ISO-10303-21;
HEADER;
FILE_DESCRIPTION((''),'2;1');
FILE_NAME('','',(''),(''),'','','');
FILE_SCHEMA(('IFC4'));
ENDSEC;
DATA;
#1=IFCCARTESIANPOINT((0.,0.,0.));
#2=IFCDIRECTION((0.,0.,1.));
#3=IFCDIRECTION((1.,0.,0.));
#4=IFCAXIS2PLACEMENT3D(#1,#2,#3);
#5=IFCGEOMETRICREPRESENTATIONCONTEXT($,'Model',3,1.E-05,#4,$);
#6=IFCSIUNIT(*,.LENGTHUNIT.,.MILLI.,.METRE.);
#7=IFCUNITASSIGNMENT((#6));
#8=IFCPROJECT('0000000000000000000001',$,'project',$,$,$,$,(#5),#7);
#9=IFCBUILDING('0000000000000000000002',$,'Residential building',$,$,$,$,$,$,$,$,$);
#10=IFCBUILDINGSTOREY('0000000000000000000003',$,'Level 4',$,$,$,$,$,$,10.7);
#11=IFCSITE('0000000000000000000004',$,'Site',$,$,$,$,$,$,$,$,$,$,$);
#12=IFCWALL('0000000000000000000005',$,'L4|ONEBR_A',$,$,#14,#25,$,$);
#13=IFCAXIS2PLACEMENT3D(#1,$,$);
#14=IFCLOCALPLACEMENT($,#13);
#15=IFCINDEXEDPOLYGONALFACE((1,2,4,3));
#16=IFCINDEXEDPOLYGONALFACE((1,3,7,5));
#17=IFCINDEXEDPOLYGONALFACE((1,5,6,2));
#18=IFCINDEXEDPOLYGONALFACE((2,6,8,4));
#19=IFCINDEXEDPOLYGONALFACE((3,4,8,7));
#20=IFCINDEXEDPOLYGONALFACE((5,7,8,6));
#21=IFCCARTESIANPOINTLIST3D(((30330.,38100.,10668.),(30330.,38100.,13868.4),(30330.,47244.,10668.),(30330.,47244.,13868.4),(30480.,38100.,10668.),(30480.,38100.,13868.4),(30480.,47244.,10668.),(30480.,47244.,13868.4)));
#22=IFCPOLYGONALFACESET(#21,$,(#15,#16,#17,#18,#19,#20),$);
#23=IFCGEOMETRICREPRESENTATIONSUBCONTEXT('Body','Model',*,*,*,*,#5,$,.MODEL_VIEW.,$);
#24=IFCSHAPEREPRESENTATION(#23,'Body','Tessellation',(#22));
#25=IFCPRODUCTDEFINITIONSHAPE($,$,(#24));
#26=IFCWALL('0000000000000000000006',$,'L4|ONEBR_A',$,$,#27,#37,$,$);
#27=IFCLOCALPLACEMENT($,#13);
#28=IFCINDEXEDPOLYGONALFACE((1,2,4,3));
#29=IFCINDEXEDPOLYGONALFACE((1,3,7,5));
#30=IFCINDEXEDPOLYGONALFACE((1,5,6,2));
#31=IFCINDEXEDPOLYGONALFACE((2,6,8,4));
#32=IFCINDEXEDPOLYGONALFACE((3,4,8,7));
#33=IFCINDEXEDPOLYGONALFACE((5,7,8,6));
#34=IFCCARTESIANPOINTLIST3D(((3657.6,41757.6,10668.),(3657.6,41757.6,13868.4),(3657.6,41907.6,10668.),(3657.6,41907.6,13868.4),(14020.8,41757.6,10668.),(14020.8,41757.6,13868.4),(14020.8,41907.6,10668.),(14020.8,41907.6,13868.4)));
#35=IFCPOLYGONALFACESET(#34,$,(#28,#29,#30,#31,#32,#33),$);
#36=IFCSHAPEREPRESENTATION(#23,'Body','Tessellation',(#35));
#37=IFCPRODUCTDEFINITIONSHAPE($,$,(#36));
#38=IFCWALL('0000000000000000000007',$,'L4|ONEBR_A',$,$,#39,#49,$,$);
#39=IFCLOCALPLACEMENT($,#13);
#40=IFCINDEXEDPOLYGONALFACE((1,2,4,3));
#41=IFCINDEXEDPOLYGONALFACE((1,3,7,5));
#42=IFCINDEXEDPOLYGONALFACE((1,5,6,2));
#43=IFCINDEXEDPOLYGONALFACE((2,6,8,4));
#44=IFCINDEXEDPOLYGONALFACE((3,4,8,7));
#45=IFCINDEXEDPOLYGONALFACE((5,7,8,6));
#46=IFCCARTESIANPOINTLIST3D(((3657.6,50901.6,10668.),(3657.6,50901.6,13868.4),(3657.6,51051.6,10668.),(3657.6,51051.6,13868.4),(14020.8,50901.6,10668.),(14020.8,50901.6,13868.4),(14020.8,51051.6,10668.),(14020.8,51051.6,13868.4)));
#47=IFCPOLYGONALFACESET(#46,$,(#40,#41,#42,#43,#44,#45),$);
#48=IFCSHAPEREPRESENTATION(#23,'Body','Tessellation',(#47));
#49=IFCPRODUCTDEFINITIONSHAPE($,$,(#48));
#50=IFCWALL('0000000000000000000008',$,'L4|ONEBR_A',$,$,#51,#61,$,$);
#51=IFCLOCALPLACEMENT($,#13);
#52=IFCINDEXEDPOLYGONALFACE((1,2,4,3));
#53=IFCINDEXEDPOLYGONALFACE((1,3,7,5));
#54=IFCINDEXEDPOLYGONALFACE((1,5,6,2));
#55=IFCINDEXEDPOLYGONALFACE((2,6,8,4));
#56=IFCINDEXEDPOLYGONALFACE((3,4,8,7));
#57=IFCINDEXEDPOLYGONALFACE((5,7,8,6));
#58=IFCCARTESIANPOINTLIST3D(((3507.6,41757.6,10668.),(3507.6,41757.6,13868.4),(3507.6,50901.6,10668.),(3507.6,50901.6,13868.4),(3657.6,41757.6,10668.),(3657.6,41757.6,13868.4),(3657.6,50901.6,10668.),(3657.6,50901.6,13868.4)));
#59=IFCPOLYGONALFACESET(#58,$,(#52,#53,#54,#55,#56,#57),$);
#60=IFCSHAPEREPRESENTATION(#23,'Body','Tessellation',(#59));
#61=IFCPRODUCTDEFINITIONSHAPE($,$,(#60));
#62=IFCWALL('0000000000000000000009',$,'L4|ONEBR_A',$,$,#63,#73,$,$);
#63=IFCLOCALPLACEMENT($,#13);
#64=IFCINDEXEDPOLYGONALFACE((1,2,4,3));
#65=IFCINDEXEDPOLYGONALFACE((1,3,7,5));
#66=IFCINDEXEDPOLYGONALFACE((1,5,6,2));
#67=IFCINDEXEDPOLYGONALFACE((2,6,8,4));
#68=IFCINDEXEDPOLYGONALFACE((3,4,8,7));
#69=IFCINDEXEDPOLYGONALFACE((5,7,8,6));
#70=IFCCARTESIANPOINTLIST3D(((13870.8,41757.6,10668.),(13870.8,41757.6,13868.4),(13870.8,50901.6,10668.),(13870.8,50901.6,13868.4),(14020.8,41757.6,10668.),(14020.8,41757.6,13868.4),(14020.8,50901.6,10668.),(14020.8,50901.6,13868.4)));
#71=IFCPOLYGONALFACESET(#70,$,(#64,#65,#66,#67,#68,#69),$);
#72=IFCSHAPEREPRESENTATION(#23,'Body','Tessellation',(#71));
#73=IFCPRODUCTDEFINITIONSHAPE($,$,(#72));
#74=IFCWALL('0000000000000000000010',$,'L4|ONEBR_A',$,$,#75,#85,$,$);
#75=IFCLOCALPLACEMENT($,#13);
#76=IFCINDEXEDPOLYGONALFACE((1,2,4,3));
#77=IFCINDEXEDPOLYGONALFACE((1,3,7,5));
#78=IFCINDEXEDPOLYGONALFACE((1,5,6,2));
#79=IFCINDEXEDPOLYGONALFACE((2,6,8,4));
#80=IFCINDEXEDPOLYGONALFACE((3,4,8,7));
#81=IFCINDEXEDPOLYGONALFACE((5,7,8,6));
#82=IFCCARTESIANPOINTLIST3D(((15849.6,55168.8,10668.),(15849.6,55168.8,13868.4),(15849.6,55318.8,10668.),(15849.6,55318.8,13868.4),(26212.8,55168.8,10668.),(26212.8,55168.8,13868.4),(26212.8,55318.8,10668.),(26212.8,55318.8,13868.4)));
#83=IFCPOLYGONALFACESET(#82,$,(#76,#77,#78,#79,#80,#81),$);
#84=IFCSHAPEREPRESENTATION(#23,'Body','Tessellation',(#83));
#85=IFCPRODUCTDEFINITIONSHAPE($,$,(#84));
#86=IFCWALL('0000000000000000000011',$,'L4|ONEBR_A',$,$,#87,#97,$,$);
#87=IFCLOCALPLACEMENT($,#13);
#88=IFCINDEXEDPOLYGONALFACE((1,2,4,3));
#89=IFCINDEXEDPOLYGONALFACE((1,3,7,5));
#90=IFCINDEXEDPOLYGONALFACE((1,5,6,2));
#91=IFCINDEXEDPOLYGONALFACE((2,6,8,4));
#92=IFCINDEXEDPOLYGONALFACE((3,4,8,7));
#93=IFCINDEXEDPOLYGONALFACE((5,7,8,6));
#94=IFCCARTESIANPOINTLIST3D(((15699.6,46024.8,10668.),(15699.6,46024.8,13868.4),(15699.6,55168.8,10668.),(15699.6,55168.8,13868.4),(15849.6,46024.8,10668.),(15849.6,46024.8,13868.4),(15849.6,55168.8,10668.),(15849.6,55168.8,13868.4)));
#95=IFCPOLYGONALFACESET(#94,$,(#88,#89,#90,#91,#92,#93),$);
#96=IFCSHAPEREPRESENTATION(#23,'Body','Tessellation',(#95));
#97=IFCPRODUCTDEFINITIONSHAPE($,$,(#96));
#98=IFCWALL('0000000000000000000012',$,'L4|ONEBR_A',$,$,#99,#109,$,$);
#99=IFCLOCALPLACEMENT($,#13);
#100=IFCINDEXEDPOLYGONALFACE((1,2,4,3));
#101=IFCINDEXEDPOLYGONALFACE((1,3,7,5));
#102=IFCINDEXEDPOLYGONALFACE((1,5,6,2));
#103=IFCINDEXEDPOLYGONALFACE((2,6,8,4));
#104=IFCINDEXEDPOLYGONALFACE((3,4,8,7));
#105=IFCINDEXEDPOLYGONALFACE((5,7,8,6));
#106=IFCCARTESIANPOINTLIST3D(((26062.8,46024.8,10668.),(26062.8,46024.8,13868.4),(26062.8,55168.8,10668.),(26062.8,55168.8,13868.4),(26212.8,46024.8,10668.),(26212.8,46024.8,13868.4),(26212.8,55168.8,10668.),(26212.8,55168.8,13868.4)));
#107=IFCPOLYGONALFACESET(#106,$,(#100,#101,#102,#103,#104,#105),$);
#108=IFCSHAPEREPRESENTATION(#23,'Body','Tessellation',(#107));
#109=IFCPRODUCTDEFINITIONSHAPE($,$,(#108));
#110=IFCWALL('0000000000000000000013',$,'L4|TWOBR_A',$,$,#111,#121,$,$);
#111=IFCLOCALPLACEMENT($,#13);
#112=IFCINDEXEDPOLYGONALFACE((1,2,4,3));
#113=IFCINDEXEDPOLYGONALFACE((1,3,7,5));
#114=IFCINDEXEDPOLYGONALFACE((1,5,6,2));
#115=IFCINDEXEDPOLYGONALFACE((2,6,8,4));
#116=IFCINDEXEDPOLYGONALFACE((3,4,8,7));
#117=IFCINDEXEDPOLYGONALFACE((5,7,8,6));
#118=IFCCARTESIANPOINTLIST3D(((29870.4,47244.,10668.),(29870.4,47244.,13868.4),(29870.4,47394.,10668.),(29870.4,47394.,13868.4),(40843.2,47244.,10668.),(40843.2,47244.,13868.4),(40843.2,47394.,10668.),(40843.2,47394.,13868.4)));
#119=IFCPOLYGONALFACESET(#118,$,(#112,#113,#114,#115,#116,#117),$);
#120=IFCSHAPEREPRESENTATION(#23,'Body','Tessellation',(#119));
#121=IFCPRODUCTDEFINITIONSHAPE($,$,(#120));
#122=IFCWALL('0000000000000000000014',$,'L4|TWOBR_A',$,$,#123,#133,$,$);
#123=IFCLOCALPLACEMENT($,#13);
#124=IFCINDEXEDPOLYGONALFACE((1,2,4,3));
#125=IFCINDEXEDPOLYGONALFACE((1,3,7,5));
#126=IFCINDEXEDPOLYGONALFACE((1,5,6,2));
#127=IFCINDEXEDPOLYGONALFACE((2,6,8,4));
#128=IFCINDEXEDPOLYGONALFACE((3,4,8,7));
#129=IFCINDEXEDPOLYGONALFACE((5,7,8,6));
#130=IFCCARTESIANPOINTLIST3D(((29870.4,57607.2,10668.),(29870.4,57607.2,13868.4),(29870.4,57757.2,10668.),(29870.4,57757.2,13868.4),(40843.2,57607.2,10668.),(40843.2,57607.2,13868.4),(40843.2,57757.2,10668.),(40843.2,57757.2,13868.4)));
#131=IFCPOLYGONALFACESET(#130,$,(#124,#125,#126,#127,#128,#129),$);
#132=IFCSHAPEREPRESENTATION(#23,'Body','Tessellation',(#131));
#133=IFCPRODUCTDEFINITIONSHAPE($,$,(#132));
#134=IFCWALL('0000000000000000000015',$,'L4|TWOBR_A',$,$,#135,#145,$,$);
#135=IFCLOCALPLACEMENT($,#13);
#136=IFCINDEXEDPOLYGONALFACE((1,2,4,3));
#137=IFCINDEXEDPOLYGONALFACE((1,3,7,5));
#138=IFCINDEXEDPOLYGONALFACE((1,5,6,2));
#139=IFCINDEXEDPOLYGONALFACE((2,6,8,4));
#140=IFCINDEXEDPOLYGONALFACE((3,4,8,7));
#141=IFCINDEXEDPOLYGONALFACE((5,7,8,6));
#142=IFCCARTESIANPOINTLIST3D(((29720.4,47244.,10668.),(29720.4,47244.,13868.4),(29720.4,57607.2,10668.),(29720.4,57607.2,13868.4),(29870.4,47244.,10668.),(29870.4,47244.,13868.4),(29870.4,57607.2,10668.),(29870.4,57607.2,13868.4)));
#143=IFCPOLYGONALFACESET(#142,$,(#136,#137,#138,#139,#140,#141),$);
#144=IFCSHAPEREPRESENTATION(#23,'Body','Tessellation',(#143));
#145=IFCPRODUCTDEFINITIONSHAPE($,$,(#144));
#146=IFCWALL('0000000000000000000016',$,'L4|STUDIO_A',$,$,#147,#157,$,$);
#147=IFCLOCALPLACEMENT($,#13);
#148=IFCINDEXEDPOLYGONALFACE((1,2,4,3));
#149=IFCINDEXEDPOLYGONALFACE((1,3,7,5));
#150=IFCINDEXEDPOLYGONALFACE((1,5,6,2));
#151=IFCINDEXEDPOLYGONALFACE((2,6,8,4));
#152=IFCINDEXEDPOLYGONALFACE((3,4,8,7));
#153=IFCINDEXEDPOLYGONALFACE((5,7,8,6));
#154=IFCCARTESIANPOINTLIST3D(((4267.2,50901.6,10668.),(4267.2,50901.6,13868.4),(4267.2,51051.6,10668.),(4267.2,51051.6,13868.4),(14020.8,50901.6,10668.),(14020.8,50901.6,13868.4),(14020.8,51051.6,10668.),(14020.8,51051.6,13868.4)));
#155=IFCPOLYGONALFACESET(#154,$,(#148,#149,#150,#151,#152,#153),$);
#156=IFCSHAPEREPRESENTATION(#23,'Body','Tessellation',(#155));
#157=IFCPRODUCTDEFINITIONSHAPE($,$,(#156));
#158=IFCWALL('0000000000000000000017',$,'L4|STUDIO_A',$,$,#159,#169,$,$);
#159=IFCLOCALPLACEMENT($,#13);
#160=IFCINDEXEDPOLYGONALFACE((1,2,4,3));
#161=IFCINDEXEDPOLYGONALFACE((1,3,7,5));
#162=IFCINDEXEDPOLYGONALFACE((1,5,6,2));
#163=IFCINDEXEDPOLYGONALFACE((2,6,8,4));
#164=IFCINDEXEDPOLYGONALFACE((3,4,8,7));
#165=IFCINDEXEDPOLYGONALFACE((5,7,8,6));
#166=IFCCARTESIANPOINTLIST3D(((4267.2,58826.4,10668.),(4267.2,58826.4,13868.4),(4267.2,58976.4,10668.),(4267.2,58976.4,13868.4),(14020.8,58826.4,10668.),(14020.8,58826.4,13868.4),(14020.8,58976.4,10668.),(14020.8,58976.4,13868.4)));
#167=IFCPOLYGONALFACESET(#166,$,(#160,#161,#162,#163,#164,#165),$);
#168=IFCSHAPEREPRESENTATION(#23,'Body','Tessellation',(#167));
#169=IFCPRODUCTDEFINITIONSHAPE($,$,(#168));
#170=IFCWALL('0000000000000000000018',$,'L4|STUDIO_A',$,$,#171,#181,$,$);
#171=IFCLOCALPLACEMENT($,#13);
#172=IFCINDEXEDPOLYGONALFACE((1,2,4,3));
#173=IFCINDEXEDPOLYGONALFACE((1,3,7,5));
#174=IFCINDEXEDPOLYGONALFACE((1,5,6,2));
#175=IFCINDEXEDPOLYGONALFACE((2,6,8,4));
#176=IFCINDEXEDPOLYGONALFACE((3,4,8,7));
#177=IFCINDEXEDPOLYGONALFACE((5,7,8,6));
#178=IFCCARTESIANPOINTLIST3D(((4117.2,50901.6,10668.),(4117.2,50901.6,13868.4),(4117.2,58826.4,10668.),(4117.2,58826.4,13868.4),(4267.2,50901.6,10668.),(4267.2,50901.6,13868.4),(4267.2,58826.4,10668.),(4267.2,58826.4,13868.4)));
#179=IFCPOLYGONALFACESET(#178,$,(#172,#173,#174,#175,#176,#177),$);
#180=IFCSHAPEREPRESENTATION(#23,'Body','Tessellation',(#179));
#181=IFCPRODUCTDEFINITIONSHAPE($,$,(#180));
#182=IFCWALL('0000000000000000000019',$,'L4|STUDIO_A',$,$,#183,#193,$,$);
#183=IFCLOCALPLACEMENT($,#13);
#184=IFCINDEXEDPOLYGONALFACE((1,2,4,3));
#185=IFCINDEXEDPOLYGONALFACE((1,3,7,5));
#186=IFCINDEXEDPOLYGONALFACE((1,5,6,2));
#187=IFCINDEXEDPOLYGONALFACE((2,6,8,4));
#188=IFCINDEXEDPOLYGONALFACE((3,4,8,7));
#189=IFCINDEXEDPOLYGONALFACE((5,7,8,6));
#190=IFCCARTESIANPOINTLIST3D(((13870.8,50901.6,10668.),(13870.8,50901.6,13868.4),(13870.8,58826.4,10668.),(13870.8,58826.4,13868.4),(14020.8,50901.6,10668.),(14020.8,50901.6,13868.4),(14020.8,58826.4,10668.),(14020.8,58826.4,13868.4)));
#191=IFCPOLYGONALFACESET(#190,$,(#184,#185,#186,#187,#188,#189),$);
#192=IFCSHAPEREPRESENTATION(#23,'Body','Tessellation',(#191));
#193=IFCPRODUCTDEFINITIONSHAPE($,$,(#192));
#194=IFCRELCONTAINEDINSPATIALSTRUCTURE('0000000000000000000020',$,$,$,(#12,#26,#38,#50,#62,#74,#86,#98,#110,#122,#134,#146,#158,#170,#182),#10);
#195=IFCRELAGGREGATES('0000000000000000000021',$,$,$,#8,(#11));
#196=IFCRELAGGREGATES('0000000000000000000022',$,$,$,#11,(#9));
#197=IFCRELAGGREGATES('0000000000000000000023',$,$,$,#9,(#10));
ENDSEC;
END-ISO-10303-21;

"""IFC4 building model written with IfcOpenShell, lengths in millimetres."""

from ifc_helpers import new_model, si_unit, frame, origin_with_axes, place, context, subcontext, project, spatial, indexed_curve, outline, extrude, element, save


model = new_model("IFC4")

# Units and contexts
model_context = context("Model", 3, precision=1e-05, world=origin_with_axes())
body_context = subcontext(model_context, "Body", "Model", "MODEL_VIEW")
ifc_project = project(units=[si_unit("LENGTHUNIT", "METRE", prefix="MILLI")], contexts=[model_context])

# Site, building, storey
site = spatial("IfcSite", under=ifc_project, Name="Site")
building = spatial("IfcBuilding", under=site, Name="Residential building")
storey = spatial("IfcBuildingStorey", under=building, Name="Level 4", Elevation=10.7)

# Walls
wall_1_placement = place(None, frame((30480.0, 38100.0, 10668.0), z_axis=(0.0, 0.0, 1.0), x_axis=(0.0, 1.0, 0.0)))
element("IfcWall", 1, at=wall_1_placement, inside=storey, Name="L4|ONEBR_A", context=body_context, shape_type="SweptSolid", body=[
    extrude(outline(indexed_curve([(0.0, 0.0), (0.0, 150.0), (9144.0, 150.0), (9144.0, 0.0), (0.0, 0.0)], self_intersect=False)), origin_with_axes(), (0.0, 0.0, 1.0), 3200.4),
])
for number, where, z_axis, x_axis, name in (
    (2, (3657.6, 41757.6, 10668.0), (0.0, 0.0, 1.0), (1.0, 0.0, 0.0), "L4|ONEBR_A"),
    (3, (3657.6, 50901.6, 10668.0), (0.0, 0.0, 1.0), (1.0, 0.0, 0.0), "L4|ONEBR_A"),
):
    element("IfcWall", number, at=place(None, frame(where, z_axis=z_axis, x_axis=x_axis)), inside=storey, Name=name, context=body_context, shape_type="SweptSolid", body=[
        extrude(outline(indexed_curve([(0.0, 0.0), (0.0, 150.0), (10363.2, 150.0), (10363.2, 0.0), (0.0, 0.0)], self_intersect=False)), origin_with_axes(), (0.0, 0.0, 1.0), 3200.4),
    ])
for number, where, z_axis, x_axis, name in (
    (4, (3657.6, 41757.6, 10668.0), (0.0, 0.0, 1.0), (0.0, 1.0, 0.0), "L4|ONEBR_A"),
    (5, (14020.8, 41757.6, 10668.0), (0.0, 0.0, 1.0), (0.0, 1.0, 0.0), "L4|ONEBR_A"),
):
    element("IfcWall", number, at=place(None, frame(where, z_axis=z_axis, x_axis=x_axis)), inside=storey, Name=name, context=body_context, shape_type="SweptSolid", body=[
        extrude(outline(indexed_curve([(0.0, 0.0), (0.0, 150.0), (9144.0, 150.0), (9144.0, 0.0), (0.0, 0.0)], self_intersect=False)), origin_with_axes(), (0.0, 0.0, 1.0), 3200.4),
    ])
for number, where, z_axis, x_axis, name in (
    (6, (15849.6, 55168.8, 10668.0), (0.0, 0.0, 1.0), (1.0, 0.0, 0.0), "L4|ONEBR_A"),
):
    element("IfcWall", number, at=place(None, frame(where, z_axis=z_axis, x_axis=x_axis)), inside=storey, Name=name, context=body_context, shape_type="SweptSolid", body=[
        extrude(outline(indexed_curve([(0.0, 0.0), (0.0, 150.0), (10363.2, 150.0), (10363.2, 0.0), (0.0, 0.0)], self_intersect=False)), origin_with_axes(), (0.0, 0.0, 1.0), 3200.4),
    ])
for number, where, z_axis, x_axis, name in (
    (7, (15849.6, 46024.8, 10668.0), (0.0, 0.0, 1.0), (0.0, 1.0, 0.0), "L4|ONEBR_A"),
    (8, (26212.8, 46024.8, 10668.0), (0.0, 0.0, 1.0), (0.0, 1.0, 0.0), "L4|ONEBR_A"),
):
    element("IfcWall", number, at=place(None, frame(where, z_axis=z_axis, x_axis=x_axis)), inside=storey, Name=name, context=body_context, shape_type="SweptSolid", body=[
        extrude(outline(indexed_curve([(0.0, 0.0), (0.0, 150.0), (9144.0, 150.0), (9144.0, 0.0), (0.0, 0.0)], self_intersect=False)), origin_with_axes(), (0.0, 0.0, 1.0), 3200.4),
    ])
for number, where, z_axis, x_axis, name in (
    (9, (29870.4, 47244.0, 10668.0), (0.0, 0.0, 1.0), (1.0, 0.0, 0.0), "L4|TWOBR_A"),
    (10, (29870.4, 57607.2, 10668.0), (0.0, 0.0, 1.0), (1.0, 0.0, 0.0), "L4|TWOBR_A"),
):
    element("IfcWall", number, at=place(None, frame(where, z_axis=z_axis, x_axis=x_axis)), inside=storey, Name=name, context=body_context, shape_type="SweptSolid", body=[
        extrude(outline(indexed_curve([(0.0, 0.0), (0.0, 150.0), (10972.8, 150.0), (10972.8, 0.0), (0.0, 0.0)], self_intersect=False)), origin_with_axes(), (0.0, 0.0, 1.0), 3200.4),
    ])
wall_2_placement = place(None, frame((29870.4, 47244.0, 10668.0), z_axis=(0.0, 0.0, 1.0), x_axis=(0.0, 1.0, 0.0)))
element("IfcWall", 11, at=wall_2_placement, inside=storey, Name="L4|TWOBR_A", context=body_context, shape_type="SweptSolid", body=[
    extrude(outline(indexed_curve([(0.0, 0.0), (0.0, 150.0), (10363.2, 150.0), (10363.2, 0.0), (0.0, 0.0)], self_intersect=False)), origin_with_axes(), (0.0, 0.0, 1.0), 3200.4),
])
for number, where, z_axis, x_axis, name in (
    (12, (4267.2, 50901.6, 10668.0), (0.0, 0.0, 1.0), (1.0, 0.0, 0.0), "L4|STUDIO_A"),
    (13, (4267.2, 58826.4, 10668.0), (0.0, 0.0, 1.0), (1.0, 0.0, 0.0), "L4|STUDIO_A"),
):
    element("IfcWall", number, at=place(None, frame(where, z_axis=z_axis, x_axis=x_axis)), inside=storey, Name=name, context=body_context, shape_type="SweptSolid", body=[
        extrude(outline(indexed_curve([(0.0, 0.0), (0.0, 150.0), (9753.6, 150.0), (9753.6, 0.0), (0.0, 0.0)], self_intersect=False)), origin_with_axes(), (0.0, 0.0, 1.0), 3200.4),
    ])
for number, where, z_axis, x_axis, name in (
    (14, (4267.2, 50901.6, 10668.0), (0.0, 0.0, 1.0), (0.0, 1.0, 0.0), "L4|STUDIO_A"),
    (15, (14020.8, 50901.6, 10668.0), (0.0, 0.0, 1.0), (0.0, 1.0, 0.0), "L4|STUDIO_A"),
):
    element("IfcWall", number, at=place(None, frame(where, z_axis=z_axis, x_axis=x_axis)), inside=storey, Name=name, context=body_context, shape_type="SweptSolid", body=[
        extrude(outline(indexed_curve([(0.0, 0.0), (0.0, 150.0), (7924.8, 150.0), (7924.8, 0.0), (0.0, 0.0)], self_intersect=False)), origin_with_axes(), (0.0, 0.0, 1.0), 3200.4),
    ])

save(model, "model.ifc")
